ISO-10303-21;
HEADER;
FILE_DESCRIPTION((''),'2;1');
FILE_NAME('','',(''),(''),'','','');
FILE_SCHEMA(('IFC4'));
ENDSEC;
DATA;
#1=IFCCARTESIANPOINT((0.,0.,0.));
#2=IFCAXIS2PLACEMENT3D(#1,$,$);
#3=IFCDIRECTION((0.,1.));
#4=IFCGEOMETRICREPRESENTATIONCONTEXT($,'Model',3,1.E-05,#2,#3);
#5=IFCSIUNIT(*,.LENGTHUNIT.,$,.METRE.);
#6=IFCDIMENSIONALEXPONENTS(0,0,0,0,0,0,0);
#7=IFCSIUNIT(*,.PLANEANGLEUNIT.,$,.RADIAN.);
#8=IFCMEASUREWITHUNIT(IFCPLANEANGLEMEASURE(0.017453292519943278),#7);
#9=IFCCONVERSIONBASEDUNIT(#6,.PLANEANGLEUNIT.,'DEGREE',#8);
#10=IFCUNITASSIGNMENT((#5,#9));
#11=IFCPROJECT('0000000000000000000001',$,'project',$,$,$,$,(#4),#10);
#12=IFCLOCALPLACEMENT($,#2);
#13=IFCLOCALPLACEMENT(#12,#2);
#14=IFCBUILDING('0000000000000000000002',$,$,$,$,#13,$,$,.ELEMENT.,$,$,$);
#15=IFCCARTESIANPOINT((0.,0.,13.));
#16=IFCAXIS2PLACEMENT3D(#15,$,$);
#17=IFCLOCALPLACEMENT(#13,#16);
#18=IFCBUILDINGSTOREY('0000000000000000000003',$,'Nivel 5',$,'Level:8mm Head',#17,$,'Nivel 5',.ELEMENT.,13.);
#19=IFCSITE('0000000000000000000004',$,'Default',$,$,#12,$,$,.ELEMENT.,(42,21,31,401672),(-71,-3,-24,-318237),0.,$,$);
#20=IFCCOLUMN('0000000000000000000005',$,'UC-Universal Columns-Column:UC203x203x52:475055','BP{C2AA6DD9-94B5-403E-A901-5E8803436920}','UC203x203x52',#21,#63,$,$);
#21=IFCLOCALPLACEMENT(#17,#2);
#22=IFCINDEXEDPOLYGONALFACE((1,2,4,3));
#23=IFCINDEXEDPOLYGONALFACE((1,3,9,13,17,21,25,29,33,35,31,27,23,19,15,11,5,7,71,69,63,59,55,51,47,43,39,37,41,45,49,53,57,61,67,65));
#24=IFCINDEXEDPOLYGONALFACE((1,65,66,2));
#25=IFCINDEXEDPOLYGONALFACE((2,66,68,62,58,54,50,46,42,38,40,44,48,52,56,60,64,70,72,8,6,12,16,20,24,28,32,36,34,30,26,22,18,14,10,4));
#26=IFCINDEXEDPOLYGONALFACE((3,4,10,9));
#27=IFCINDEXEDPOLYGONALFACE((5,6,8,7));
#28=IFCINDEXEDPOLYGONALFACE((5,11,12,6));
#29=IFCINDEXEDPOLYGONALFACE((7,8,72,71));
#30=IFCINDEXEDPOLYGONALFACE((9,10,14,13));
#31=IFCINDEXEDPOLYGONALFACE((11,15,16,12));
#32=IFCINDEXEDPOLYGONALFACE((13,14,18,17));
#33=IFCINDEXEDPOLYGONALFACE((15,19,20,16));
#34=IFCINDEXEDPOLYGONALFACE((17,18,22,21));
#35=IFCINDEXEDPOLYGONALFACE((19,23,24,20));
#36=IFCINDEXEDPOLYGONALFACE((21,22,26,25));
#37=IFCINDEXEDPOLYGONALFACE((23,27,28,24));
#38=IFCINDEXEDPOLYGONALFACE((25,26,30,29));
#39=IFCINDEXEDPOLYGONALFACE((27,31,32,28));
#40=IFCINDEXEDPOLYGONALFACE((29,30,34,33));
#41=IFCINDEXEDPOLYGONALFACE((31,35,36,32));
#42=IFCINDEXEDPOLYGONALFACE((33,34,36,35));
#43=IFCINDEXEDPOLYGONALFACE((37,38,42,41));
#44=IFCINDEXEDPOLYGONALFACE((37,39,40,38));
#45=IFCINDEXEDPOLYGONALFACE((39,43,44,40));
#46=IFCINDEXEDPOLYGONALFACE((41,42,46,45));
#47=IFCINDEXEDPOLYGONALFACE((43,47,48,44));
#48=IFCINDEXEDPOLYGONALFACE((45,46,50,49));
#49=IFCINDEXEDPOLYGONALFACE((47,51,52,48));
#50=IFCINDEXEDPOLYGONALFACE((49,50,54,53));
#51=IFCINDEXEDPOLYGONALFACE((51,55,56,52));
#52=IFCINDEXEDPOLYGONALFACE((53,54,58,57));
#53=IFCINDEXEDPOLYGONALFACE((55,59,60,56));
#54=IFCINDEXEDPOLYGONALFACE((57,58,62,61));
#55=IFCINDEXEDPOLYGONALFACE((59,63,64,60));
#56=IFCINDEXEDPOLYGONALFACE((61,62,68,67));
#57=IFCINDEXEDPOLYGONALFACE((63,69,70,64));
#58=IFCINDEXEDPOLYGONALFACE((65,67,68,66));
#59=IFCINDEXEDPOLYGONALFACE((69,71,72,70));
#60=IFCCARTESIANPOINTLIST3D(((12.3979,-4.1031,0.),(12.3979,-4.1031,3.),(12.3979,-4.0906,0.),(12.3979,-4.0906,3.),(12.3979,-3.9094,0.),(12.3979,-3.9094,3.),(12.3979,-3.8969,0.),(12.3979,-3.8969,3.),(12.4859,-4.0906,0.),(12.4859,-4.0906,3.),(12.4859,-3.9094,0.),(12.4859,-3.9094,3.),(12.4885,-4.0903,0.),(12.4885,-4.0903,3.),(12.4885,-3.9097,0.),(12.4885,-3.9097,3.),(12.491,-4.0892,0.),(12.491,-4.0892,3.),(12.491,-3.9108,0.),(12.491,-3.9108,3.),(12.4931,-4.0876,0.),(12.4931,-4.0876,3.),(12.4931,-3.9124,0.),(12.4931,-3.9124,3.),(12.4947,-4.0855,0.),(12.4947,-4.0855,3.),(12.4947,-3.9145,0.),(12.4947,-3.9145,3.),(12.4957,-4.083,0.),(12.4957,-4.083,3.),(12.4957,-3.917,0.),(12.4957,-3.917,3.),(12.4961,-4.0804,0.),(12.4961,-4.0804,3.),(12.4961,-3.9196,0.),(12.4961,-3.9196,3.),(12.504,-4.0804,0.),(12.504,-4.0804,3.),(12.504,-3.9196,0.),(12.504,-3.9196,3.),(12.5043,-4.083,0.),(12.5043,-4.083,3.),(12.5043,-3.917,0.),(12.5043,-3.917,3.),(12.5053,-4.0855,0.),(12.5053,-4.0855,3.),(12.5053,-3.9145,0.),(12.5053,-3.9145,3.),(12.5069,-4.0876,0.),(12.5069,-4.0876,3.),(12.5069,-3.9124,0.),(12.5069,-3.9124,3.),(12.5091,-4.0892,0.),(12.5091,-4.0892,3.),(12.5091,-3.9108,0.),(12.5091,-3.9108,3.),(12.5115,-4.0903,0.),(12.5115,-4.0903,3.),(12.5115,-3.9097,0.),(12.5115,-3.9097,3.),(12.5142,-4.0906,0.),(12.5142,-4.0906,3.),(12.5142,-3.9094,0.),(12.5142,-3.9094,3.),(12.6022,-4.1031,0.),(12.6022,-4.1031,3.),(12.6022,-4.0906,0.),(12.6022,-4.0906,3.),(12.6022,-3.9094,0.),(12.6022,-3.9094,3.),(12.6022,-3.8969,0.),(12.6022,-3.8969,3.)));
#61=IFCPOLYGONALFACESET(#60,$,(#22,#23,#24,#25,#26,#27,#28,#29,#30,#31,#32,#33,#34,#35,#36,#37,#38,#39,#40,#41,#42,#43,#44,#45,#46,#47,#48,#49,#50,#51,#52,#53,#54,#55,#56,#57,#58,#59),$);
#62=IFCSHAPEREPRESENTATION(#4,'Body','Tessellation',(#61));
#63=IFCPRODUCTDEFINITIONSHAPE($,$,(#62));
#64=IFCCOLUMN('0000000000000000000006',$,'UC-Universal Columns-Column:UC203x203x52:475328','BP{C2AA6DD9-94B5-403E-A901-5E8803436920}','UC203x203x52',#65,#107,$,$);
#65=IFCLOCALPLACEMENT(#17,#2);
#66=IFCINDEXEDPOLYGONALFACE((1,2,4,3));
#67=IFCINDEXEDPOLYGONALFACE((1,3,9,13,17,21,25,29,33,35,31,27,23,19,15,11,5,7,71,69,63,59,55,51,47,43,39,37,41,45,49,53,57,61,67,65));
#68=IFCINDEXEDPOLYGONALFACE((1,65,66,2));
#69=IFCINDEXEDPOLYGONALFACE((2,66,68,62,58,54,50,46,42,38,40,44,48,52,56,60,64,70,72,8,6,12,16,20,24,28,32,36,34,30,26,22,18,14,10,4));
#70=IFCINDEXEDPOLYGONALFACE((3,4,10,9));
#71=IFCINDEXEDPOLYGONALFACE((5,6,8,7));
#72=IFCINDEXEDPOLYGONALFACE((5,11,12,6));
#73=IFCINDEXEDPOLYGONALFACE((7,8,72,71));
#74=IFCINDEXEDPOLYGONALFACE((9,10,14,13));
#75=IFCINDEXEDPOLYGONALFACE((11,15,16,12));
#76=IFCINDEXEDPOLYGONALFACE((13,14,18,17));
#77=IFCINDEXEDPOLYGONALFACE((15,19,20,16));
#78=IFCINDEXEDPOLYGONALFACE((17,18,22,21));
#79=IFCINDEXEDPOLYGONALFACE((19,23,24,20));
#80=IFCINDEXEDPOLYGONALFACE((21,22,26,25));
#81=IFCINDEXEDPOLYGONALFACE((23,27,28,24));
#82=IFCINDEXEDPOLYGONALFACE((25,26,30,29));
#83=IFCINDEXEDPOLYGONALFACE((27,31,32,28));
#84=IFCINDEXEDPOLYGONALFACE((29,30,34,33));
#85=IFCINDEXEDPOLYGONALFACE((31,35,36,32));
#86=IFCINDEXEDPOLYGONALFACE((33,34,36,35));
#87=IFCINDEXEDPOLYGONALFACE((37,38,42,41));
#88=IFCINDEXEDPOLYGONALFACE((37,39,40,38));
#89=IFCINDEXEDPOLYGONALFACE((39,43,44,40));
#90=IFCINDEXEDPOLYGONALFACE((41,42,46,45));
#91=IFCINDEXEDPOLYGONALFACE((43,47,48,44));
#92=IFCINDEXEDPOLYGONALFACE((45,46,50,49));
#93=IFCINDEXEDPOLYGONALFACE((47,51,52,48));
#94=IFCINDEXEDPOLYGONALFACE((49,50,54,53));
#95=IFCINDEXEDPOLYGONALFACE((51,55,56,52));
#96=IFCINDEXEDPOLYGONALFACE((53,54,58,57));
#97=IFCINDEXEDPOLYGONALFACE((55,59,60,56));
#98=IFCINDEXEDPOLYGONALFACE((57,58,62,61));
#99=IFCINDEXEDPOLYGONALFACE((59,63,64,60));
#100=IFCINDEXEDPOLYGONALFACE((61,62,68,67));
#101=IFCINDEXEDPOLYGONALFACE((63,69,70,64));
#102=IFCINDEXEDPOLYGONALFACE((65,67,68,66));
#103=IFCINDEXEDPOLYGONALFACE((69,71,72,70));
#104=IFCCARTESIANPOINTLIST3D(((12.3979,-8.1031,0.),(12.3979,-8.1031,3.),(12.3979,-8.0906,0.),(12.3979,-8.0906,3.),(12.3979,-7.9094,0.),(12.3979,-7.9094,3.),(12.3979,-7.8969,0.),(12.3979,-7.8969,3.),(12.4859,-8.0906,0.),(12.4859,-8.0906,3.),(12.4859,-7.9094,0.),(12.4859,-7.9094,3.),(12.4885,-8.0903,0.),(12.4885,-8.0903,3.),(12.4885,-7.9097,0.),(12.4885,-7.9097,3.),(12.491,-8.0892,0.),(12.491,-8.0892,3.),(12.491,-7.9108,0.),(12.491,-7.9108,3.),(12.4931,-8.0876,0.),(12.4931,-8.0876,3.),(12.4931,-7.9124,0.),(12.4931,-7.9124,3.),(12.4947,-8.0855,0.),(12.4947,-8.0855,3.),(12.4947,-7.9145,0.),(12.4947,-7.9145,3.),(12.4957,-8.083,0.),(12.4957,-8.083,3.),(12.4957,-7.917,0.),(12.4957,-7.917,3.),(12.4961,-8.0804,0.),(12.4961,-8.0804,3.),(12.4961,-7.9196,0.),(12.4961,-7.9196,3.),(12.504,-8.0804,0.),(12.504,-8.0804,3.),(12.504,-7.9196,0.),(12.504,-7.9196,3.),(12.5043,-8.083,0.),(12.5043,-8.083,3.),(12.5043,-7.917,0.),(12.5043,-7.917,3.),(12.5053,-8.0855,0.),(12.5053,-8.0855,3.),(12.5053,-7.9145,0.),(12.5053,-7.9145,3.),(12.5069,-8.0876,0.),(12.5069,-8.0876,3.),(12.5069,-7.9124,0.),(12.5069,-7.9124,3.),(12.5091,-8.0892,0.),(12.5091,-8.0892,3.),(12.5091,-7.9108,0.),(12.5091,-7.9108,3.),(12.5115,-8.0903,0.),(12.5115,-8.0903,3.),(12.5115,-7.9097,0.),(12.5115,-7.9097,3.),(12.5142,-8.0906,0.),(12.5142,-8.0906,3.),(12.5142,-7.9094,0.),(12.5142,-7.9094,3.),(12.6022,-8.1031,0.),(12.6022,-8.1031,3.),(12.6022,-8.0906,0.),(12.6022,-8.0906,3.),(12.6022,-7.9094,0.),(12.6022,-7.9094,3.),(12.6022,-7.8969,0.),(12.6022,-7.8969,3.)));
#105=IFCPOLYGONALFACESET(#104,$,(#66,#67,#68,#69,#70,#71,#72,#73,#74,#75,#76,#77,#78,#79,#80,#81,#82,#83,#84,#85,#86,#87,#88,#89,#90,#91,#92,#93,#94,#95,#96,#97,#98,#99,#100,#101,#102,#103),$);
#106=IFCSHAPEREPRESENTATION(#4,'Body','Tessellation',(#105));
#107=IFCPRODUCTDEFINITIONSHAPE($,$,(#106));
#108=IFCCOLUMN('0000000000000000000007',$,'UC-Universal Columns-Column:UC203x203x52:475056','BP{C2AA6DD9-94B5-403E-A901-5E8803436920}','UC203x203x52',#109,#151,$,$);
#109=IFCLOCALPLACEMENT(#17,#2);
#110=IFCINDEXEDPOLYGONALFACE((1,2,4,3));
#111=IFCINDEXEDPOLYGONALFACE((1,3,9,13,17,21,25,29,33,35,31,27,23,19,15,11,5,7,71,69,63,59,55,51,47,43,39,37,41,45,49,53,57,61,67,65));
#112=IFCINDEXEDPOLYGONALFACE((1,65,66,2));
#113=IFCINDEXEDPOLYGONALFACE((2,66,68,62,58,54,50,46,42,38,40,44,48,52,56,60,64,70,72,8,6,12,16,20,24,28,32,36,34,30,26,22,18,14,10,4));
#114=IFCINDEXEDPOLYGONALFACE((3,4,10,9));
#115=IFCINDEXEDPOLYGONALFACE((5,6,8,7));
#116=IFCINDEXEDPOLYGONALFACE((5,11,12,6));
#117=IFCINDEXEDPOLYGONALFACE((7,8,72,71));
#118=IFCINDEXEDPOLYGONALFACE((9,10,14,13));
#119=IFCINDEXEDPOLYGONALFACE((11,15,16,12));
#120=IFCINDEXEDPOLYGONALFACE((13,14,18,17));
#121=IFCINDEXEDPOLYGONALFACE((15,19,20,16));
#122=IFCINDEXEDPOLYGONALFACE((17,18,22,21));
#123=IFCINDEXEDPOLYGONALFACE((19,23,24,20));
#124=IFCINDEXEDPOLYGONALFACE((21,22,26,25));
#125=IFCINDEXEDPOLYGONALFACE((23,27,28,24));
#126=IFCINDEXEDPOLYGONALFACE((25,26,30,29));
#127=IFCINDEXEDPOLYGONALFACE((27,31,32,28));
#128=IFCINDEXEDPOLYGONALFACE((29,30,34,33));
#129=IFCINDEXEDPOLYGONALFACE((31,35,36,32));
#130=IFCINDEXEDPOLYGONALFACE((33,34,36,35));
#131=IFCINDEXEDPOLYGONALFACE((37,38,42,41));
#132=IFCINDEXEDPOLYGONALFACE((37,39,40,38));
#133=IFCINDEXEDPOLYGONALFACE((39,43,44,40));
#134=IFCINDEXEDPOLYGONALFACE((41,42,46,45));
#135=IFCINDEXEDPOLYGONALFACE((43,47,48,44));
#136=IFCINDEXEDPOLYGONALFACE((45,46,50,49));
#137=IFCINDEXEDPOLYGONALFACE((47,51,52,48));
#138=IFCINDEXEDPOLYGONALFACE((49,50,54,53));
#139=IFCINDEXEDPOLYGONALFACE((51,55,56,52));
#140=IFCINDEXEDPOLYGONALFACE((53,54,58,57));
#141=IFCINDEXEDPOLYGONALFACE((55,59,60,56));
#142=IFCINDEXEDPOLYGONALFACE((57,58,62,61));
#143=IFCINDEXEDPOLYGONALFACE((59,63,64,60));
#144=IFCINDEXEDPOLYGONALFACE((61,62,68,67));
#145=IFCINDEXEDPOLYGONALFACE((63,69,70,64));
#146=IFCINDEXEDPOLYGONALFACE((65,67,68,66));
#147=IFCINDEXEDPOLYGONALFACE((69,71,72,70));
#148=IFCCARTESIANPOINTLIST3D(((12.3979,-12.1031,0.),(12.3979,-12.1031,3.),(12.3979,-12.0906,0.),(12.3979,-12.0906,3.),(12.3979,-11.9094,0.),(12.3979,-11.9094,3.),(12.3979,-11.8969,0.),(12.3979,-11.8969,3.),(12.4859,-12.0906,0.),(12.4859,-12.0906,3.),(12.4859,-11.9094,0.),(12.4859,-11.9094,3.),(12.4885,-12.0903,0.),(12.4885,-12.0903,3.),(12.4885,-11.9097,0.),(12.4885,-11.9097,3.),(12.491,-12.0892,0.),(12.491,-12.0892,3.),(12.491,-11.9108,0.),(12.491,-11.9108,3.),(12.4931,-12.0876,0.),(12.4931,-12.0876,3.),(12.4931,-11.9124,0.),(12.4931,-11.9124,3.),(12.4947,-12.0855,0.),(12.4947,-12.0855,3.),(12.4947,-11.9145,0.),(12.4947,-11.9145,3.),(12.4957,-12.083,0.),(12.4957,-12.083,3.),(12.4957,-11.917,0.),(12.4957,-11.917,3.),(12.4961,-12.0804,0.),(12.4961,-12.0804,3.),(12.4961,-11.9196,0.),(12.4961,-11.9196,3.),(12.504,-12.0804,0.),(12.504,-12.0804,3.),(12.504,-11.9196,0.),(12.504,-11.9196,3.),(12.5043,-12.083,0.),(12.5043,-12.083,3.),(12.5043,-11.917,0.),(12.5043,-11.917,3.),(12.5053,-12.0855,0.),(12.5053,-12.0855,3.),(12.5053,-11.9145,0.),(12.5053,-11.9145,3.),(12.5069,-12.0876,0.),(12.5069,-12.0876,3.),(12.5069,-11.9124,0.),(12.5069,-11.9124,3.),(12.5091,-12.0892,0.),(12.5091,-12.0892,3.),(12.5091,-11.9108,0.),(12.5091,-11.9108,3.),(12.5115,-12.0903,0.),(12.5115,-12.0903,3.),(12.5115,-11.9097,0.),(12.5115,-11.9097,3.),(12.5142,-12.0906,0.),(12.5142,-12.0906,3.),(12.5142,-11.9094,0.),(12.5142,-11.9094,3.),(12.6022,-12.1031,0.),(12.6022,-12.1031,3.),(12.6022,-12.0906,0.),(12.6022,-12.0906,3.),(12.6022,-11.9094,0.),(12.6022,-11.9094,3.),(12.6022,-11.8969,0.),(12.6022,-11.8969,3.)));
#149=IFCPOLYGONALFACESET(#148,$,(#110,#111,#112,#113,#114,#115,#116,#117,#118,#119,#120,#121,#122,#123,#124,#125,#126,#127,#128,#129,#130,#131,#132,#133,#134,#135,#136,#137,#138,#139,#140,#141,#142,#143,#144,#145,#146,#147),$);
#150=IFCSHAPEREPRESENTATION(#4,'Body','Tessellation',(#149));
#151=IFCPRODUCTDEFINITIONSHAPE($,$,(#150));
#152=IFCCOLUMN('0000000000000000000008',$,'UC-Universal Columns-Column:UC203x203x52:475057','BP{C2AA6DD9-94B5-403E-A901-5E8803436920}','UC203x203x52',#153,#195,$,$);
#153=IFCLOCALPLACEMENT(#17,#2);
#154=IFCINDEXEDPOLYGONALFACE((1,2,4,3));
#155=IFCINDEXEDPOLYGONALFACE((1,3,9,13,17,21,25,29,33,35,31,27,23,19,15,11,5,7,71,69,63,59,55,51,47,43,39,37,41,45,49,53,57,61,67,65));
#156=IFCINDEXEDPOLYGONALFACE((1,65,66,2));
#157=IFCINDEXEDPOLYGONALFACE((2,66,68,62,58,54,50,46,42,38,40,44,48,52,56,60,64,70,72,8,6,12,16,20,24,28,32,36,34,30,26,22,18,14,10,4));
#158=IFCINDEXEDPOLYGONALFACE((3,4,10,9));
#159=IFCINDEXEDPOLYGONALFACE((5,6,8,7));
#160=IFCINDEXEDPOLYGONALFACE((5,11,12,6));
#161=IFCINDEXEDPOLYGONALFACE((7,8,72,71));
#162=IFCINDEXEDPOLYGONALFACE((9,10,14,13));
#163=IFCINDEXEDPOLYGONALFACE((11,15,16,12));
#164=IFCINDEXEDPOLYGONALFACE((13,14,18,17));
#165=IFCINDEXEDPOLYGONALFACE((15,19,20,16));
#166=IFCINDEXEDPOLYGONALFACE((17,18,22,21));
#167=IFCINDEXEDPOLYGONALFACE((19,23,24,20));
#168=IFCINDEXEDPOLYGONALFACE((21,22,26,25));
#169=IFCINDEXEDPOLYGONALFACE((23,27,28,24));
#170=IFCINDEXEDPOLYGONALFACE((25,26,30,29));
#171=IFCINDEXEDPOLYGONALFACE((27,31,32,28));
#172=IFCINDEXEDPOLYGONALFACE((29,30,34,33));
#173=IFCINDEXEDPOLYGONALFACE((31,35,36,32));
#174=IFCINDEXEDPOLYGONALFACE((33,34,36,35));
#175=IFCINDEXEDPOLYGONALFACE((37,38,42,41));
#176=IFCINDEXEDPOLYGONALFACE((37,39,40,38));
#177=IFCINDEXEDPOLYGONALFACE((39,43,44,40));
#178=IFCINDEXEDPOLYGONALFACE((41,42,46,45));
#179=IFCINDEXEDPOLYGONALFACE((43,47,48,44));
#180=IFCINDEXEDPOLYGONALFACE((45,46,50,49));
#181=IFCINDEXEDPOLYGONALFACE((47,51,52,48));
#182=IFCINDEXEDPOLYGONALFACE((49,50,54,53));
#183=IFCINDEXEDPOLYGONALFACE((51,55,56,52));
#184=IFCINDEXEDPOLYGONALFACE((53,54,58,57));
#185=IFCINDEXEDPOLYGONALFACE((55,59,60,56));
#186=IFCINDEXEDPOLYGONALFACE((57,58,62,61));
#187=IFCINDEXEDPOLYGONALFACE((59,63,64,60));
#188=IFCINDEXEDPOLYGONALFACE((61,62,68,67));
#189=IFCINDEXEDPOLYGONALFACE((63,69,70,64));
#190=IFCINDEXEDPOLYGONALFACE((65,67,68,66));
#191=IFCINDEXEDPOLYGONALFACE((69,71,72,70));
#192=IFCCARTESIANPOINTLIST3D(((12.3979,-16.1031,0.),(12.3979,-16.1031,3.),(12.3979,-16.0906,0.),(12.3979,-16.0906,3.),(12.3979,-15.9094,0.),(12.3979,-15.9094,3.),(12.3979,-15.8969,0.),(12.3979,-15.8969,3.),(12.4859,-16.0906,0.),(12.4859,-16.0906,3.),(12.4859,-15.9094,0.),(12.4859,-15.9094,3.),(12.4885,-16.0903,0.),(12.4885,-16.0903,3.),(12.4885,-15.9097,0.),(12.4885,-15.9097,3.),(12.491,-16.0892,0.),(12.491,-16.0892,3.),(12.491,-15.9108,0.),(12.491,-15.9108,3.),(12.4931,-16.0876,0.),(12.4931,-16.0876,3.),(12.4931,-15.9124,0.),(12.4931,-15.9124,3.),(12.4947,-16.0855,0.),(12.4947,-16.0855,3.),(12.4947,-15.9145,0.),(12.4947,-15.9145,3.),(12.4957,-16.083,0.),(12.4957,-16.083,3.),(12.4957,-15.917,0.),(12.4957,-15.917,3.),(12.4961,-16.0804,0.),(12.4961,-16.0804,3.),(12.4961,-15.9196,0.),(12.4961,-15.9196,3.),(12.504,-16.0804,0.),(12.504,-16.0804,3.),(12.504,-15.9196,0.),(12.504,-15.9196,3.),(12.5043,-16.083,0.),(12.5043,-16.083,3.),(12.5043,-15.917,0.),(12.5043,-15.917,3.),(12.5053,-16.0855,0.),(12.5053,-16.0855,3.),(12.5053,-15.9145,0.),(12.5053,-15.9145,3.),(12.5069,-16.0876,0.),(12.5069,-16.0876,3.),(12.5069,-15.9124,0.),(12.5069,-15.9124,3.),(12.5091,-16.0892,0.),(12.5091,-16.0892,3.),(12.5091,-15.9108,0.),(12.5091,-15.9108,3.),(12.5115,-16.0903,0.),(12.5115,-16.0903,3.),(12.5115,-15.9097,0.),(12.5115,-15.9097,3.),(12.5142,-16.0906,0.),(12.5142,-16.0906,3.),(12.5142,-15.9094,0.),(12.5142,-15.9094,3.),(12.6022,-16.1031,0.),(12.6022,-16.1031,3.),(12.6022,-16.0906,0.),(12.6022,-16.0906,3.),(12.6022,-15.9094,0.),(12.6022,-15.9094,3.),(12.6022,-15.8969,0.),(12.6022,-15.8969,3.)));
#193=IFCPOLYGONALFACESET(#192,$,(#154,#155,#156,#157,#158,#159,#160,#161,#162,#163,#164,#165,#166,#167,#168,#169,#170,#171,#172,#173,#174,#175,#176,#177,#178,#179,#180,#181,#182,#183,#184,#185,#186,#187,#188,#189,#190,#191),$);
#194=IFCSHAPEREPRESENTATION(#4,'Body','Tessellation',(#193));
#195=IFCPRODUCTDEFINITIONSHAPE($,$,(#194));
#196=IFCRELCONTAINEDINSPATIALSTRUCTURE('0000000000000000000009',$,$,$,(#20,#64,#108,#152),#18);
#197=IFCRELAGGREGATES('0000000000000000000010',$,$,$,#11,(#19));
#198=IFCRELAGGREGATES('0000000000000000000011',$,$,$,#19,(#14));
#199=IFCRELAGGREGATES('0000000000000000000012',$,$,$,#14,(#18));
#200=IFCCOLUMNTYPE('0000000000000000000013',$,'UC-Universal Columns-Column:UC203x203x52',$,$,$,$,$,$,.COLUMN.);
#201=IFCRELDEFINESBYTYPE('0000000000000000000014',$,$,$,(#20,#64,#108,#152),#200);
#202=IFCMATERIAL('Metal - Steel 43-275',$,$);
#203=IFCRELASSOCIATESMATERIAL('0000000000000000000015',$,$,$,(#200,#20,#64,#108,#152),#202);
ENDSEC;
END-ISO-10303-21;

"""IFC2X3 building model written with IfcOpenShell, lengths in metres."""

from ifc_helpers import new_model, entity, si_unit, converted_unit, direction, frame, origin, origin_2d, place, context, project, spatial, i_section, extrude, material, type_object, element, save


model = new_model("IFC2X3")

# Units and contexts
model_context = context("Model", 3, precision=1e-05, world=origin(), true_north=direction((0.0, 1.0)))
ifc_project = project(units=[si_unit("LENGTHUNIT", "METRE"), converted_unit("PLANEANGLEUNIT", "DEGREE", entity("IfcPlaneAngleMeasure", 0.017453292519943278), si_unit("PLANEANGLEUNIT", "RADIAN"), dimensions=[0, 0, 0, 0, 0, 0, 0])], contexts=[model_context])

# Site, building, storey
site_placement = place(None, origin())
site = spatial("IfcSite", under=ifc_project, at=site_placement, Name="Default", CompositionType="ELEMENT", RefLatitude=(42, 21, 31, 401672), RefLongitude=(-71, -3, -24, -318237), RefElevation=0.0)
building_placement = place(site_placement, origin())
building = spatial("IfcBuilding", under=site, at=building_placement, CompositionType="ELEMENT")
storey_placement = place(building_placement, frame((0.0, 0.0, 13.0)))
storey = spatial("IfcBuildingStorey", under=building, at=storey_placement, Name="Nivel 5", ObjectType="Level:8mm Head", LongName="Nivel 5", CompositionType="ELEMENT", Elevation=13.0)

# Columns
ifc_material_1 = material(Name="Metal - Steel 43-275")
column_type_1 = type_object("IfcColumnType", Name="UC-Universal Columns-Column:UC203x203x52", PredefinedType="COLUMN", material=ifc_material_1)
for number, where, name in (
    (1, (12.5, -4.0, 3.0), "UC-Universal Columns-Column:UC203x203x52:475055"),
    (2, (12.5, -8.0, 3.0), "UC-Universal Columns-Column:UC203x203x52:475328"),
    (3, (12.5, -12.0, 3.0), "UC-Universal Columns-Column:UC203x203x52:475056"),
    (4, (12.5, -16.0, 3.0), "UC-Universal Columns-Column:UC203x203x52:475057"),
):
    element("IfcColumn", number, at=place(storey_placement, frame(where)), inside=storey, type_object=column_type_1, material=ifc_material_1, Name=name, Description="BP{C2AA6DD9-94B5-403E-A901-5E8803436920}", ObjectType="UC203x203x52", context=model_context, shape_type="SweptSolid", body=[
        extrude(i_section(OverallWidth=0.2043, OverallDepth=0.2062, WebThickness=0.0079, FlangeThickness=0.0125, FilletRadius=0.0102, at=origin_2d()), origin(), (0.0, 0.0, -1.0), 3.0),
    ])

save(model, "model.ifc")
